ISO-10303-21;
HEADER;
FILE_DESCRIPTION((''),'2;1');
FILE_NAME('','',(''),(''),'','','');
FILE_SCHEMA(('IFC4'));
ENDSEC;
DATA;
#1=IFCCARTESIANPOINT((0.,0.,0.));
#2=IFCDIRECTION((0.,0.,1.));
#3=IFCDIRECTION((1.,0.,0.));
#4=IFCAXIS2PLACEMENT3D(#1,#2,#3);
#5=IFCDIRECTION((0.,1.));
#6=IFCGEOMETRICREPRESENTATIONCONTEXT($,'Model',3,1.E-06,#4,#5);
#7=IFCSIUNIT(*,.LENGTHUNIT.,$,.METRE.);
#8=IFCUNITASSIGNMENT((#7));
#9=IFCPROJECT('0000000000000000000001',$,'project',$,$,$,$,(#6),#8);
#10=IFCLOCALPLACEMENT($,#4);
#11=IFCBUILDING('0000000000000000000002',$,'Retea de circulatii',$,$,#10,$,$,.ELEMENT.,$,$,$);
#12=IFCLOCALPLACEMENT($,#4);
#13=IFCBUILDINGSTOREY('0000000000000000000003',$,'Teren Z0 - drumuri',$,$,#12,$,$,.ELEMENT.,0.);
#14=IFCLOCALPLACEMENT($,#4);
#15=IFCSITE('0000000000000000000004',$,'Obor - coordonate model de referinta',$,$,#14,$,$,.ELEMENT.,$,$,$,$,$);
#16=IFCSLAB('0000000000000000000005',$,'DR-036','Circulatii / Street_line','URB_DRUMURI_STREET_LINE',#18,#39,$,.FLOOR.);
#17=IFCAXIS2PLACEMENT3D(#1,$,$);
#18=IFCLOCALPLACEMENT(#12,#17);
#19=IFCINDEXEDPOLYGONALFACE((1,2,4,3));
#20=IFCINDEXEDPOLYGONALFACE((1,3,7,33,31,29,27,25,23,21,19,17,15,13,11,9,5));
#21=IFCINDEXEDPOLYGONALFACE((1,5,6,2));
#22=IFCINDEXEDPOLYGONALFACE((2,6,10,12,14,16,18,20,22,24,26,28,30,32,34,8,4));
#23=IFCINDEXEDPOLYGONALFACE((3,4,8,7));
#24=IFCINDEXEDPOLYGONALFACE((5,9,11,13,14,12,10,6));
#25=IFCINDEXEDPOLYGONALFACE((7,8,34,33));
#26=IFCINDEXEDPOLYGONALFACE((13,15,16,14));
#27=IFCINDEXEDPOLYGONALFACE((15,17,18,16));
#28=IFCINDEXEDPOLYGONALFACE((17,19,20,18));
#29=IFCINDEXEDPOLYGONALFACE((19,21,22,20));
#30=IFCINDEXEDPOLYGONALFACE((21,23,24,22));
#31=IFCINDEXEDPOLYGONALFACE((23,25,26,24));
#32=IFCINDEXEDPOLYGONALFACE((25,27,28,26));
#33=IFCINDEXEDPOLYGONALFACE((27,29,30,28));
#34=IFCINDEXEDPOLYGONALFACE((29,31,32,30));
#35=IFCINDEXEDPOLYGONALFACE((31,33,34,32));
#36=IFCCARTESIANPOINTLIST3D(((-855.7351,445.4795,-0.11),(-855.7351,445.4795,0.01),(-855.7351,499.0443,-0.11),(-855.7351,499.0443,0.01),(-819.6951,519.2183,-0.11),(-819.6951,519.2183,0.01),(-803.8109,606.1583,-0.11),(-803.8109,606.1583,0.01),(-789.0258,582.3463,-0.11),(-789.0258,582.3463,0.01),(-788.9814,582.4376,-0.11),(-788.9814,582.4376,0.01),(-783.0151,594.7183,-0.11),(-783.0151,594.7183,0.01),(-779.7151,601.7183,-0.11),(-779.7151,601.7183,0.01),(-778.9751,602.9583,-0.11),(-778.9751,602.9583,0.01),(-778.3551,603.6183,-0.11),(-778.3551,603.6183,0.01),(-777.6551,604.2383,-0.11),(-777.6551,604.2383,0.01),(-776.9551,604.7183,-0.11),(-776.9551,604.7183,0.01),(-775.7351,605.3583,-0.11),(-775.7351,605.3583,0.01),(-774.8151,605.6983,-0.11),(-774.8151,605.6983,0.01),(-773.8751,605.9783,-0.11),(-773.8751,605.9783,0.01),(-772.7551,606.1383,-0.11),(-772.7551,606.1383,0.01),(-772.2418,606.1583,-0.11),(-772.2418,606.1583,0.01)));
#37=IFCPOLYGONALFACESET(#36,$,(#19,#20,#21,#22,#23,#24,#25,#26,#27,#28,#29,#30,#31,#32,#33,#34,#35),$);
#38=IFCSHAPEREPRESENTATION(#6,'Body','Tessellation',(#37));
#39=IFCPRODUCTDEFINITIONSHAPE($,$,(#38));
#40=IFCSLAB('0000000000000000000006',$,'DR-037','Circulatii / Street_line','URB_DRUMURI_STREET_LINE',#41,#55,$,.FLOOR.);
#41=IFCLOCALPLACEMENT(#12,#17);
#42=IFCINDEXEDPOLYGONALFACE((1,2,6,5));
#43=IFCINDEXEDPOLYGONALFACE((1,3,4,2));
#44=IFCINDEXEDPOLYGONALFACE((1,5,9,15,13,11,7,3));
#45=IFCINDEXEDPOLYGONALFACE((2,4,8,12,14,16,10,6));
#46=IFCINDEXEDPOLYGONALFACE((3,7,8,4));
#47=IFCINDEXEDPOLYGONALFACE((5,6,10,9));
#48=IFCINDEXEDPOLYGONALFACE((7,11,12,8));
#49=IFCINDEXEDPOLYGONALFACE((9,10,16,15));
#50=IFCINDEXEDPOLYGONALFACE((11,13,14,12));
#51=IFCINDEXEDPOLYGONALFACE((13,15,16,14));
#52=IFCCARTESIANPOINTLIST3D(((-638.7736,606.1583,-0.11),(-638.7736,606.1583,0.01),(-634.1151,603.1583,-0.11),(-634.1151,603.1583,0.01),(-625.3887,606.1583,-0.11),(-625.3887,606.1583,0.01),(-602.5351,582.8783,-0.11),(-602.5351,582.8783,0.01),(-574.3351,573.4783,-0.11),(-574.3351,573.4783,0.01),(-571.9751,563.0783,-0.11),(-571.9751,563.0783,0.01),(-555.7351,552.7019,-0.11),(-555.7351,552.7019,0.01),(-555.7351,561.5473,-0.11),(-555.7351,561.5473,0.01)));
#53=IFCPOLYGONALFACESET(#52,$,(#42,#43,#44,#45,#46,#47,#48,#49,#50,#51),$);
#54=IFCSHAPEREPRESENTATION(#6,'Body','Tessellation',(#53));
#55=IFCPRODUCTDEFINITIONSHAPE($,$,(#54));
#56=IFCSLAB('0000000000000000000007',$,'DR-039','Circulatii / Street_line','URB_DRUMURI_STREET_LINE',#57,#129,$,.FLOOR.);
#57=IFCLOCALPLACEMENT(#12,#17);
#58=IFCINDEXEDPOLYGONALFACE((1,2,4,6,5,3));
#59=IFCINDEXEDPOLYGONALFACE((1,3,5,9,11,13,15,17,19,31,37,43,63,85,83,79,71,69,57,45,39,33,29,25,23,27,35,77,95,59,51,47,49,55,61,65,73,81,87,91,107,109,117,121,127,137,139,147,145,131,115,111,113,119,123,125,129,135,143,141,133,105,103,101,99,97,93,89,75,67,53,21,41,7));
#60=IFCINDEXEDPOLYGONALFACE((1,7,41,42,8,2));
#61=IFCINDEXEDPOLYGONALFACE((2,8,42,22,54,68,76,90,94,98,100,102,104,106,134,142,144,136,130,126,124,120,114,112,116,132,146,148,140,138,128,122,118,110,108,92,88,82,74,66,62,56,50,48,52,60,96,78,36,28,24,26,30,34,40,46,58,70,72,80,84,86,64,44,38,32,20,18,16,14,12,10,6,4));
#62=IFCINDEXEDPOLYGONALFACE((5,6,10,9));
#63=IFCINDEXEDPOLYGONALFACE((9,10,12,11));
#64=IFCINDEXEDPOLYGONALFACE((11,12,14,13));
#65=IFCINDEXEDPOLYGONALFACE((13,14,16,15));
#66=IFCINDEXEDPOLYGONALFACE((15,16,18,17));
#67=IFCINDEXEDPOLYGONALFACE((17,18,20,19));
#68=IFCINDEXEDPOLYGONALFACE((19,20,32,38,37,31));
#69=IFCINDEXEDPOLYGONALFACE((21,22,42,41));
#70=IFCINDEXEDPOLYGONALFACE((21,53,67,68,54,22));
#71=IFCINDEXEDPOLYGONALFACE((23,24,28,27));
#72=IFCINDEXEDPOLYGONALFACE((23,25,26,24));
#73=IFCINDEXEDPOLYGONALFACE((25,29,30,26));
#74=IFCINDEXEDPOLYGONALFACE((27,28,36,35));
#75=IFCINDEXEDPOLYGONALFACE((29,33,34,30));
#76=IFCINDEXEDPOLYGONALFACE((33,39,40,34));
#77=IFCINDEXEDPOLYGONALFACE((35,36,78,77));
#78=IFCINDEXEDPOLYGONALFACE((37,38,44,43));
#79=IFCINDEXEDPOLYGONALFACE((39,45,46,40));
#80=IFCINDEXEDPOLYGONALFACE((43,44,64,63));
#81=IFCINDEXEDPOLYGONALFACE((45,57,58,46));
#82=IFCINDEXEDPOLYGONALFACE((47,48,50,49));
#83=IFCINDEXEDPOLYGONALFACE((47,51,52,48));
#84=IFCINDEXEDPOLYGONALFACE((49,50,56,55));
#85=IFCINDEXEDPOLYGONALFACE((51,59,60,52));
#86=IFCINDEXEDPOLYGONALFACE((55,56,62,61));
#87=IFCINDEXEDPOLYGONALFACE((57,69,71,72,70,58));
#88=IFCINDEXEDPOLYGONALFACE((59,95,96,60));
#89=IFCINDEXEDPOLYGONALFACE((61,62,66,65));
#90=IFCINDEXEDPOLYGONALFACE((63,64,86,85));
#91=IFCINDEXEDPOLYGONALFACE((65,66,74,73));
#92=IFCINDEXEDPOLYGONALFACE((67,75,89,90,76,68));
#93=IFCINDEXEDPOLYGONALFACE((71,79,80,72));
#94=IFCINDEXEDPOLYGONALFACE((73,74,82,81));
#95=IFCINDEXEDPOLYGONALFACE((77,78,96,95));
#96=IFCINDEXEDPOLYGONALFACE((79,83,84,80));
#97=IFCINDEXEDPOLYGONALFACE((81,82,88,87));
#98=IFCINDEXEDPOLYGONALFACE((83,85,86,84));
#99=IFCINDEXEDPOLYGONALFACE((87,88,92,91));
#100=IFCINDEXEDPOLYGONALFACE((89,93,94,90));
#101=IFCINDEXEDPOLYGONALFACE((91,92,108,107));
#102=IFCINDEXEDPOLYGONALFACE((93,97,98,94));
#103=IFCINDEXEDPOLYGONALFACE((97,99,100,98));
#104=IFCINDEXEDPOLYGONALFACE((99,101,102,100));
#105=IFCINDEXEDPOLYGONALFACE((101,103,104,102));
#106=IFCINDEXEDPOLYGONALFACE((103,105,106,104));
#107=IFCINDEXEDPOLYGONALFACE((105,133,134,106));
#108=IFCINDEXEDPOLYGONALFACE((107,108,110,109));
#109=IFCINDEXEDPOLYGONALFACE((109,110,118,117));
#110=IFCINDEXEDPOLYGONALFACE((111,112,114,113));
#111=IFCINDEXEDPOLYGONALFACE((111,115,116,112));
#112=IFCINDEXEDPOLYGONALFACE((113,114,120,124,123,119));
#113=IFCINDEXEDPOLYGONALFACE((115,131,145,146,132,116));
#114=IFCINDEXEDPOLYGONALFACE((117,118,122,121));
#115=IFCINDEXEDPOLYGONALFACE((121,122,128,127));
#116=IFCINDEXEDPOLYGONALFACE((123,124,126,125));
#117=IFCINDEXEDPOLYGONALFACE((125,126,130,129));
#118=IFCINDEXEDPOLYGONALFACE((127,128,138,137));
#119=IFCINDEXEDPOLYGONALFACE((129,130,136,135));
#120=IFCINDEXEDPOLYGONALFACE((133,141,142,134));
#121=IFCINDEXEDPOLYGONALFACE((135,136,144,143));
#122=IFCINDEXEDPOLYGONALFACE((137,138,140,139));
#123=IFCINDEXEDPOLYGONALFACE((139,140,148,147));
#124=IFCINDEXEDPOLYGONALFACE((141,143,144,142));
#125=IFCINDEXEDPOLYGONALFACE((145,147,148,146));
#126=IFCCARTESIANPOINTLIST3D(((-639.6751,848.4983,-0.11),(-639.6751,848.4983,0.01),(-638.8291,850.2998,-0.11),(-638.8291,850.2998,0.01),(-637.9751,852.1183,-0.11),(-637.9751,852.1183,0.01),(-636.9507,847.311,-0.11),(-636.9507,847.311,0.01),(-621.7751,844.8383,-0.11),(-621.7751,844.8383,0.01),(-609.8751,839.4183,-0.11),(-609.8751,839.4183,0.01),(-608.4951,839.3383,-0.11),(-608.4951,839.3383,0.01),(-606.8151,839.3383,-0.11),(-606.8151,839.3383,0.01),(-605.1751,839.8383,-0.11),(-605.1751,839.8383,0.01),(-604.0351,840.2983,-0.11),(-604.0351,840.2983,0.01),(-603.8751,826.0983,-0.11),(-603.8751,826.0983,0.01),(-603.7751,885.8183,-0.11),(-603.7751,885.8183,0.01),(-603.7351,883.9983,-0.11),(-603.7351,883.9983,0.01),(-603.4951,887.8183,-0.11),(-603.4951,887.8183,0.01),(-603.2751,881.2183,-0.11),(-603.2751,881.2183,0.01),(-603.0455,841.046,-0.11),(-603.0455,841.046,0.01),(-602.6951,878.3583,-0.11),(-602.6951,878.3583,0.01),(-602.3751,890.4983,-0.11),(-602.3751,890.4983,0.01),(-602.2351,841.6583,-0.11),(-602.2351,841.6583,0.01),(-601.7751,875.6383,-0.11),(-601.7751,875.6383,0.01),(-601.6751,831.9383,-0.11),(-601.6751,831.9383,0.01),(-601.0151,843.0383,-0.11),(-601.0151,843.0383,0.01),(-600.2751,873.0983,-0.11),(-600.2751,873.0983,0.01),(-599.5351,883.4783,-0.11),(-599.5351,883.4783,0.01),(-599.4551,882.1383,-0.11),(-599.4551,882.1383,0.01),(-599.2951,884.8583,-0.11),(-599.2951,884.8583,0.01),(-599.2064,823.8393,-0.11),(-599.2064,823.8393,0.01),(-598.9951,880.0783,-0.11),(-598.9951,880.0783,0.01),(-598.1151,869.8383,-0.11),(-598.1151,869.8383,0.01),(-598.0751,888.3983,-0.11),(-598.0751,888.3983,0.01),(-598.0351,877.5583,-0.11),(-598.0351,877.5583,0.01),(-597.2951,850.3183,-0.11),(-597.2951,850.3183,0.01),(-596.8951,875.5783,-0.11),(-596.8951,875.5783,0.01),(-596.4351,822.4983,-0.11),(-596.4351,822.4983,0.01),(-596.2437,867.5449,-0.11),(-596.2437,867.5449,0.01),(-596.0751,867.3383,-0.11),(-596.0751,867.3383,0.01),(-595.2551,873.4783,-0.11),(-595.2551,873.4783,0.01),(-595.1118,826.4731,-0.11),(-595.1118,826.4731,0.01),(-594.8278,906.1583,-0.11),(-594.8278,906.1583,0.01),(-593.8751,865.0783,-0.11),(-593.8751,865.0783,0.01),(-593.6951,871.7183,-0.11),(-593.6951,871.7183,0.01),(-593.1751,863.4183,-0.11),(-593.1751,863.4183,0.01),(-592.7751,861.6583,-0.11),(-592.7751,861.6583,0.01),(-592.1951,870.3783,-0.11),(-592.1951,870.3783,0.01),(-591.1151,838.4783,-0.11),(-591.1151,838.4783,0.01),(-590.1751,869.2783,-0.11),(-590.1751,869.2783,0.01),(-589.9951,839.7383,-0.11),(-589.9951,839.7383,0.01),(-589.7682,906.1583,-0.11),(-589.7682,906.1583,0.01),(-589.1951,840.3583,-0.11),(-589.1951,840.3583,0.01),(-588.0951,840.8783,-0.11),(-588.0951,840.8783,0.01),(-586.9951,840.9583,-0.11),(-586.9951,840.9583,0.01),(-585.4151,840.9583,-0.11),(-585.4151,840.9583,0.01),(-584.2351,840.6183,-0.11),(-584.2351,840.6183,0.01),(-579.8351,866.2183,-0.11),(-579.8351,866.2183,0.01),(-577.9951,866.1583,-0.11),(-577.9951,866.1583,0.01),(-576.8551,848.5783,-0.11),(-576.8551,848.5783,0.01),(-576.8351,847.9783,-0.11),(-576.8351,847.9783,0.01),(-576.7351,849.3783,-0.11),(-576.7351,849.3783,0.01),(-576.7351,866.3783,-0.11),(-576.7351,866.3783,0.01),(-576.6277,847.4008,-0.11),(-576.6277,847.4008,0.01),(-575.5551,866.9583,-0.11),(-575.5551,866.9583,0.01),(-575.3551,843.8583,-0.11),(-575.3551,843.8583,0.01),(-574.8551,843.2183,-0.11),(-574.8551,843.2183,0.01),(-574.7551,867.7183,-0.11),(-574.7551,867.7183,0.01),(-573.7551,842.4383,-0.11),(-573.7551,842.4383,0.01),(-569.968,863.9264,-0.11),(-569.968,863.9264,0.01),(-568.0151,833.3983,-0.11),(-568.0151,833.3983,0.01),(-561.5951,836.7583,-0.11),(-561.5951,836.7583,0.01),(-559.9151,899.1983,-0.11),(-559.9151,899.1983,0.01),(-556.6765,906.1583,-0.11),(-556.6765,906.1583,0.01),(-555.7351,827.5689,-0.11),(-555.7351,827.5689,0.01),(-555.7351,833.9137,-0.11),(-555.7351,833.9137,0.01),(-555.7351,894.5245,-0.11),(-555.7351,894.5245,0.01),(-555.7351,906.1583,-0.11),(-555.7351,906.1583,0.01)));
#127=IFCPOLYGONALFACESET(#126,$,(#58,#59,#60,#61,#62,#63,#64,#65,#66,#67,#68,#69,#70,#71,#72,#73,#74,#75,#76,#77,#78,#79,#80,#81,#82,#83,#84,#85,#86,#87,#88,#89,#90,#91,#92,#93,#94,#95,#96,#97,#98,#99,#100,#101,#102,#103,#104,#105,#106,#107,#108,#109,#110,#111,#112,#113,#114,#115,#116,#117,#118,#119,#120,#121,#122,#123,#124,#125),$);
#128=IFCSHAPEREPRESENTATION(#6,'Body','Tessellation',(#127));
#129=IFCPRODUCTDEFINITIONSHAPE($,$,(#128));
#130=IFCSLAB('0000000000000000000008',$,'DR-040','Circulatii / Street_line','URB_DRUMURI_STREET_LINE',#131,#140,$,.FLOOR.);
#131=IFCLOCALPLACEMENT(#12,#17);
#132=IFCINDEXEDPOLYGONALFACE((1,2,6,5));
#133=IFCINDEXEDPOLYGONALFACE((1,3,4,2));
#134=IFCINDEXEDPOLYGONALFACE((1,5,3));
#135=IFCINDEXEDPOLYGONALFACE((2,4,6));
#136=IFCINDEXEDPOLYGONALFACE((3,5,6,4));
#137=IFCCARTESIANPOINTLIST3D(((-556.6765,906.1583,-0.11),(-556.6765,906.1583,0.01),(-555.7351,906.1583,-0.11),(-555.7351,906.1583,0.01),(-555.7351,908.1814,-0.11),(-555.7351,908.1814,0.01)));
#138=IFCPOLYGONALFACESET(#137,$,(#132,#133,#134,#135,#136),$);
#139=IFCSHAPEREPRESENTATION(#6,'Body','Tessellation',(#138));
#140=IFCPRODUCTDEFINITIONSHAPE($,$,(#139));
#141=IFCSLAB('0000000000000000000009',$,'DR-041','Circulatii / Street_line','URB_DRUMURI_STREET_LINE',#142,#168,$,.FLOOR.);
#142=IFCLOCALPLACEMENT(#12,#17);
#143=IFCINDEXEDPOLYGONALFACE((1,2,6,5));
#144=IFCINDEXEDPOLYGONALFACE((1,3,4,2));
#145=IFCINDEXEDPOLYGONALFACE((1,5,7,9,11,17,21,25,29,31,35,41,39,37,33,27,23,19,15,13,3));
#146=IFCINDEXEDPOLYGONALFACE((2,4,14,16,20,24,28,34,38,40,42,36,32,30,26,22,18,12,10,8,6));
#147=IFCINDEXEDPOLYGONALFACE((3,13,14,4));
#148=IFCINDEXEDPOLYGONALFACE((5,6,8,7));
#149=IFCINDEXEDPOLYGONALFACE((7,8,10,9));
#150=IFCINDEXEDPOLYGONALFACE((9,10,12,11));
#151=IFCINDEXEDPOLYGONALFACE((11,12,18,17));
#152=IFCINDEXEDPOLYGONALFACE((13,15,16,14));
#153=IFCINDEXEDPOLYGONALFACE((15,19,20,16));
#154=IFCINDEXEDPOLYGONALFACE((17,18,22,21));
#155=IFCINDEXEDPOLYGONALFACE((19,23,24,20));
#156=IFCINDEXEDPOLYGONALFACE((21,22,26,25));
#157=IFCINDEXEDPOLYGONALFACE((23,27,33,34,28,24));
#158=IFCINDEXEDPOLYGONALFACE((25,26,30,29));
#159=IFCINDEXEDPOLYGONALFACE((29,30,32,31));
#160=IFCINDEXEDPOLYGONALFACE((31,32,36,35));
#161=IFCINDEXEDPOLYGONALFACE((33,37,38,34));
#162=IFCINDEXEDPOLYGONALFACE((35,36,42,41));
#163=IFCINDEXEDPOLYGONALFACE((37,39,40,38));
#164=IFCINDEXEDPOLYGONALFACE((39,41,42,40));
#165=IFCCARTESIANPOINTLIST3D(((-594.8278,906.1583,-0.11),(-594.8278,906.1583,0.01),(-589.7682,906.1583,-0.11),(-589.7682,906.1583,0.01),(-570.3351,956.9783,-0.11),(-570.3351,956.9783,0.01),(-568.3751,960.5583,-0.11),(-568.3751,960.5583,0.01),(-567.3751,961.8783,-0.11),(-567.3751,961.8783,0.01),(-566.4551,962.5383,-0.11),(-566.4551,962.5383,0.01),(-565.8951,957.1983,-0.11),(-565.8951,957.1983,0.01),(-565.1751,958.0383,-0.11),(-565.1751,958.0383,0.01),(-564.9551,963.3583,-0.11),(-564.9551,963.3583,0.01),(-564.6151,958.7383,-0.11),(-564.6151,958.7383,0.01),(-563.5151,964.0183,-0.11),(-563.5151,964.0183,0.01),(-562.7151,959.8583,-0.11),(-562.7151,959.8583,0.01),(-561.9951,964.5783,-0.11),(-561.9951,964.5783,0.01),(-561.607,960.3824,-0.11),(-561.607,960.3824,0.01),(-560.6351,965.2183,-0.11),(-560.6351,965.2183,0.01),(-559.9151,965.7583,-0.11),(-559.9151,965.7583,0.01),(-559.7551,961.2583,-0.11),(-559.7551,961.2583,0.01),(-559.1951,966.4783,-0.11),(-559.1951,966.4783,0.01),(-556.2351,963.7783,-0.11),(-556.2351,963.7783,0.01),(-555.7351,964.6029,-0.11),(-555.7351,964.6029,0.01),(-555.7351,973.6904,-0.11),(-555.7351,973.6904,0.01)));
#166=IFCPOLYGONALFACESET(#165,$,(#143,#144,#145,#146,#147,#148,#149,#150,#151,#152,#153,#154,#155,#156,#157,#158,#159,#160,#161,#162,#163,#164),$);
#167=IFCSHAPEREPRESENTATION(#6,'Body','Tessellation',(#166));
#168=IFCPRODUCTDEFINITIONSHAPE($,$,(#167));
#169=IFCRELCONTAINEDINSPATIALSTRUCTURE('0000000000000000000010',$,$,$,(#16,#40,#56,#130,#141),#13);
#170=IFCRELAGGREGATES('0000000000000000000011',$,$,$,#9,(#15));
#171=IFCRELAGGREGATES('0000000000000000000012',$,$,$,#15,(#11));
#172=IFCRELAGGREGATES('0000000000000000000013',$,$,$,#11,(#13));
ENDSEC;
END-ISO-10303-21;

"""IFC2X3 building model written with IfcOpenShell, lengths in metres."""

from ifc_helpers import new_model, si_unit, direction, frame, origin_with_axes, place, context, project, spatial, polyline, outline, extrude, element, save


model = new_model("IFC2X3")

# Units and contexts
model_context = context("Model", 3, precision=1e-06, world=origin_with_axes(), true_north=direction((0.0, 1.0)))
ifc_project = project(units=[si_unit("LENGTHUNIT", "METRE")], contexts=[model_context])

# Site, building, storey
site_placement = place(None, origin_with_axes())
site = spatial("IfcSite", under=ifc_project, at=site_placement, Name="Obor - coordonate model de referinta", CompositionType="ELEMENT")
building_placement = place(None, origin_with_axes())
building = spatial("IfcBuilding", under=site, at=building_placement, Name="Retea de circulatii", CompositionType="ELEMENT")
storey_placement = place(None, origin_with_axes())
storey = spatial("IfcBuildingStorey", under=building, at=storey_placement, Name="Teren Z0 - drumuri", CompositionType="ELEMENT", Elevation=0.0)

# Slabs
slab_1_placement = place(None, origin_with_axes())
element("IfcSlab", 1, at=slab_1_placement, inside=storey, Name="DR-036", Description="Circulatii / Street_line", ObjectType="URB_DRUMURI_STREET_LINE", PredefinedType="FLOOR", context=model_context, shape_type="SweptSolid", body=[
    extrude(outline(polyline([(-772.7551, 606.1383), (-772.2418, 606.1583), (-803.8109, 606.1583), (-855.7351, 499.0443), (-855.7351, 445.4795), (-819.6951, 519.2183), (-789.0258, 582.3463), (-788.9814, 582.4376), (-783.0151, 594.7183), (-779.7151, 601.7183), (-778.9751, 602.9583), (-778.3551, 603.6183), (-777.6551, 604.2383), (-776.9551, 604.7183), (-775.7351, 605.3583), (-774.8151, 605.6983), (-773.8751, 605.9783), (-772.7551, 606.1383)])), frame((0.0, 0.0, -0.11), z_axis=(0.0, 0.0, 1.0), x_axis=(1.0, 0.0, 0.0)), (0.0, 0.0, 1.0), 0.12),
])
slab_2_placement = place(None, origin_with_axes())
element("IfcSlab", 2, at=slab_2_placement, inside=storey, Name="DR-037", Description="Circulatii / Street_line", ObjectType="URB_DRUMURI_STREET_LINE", PredefinedType="FLOOR", context=model_context, shape_type="SweptSolid", body=[
    extrude(outline(polyline([(-634.1151, 603.1583), (-602.5351, 582.8783), (-571.9751, 563.0783), (-555.7351, 552.7019), (-555.7351, 561.5473), (-574.3351, 573.4783), (-625.3887, 606.1583), (-638.7736, 606.1583), (-634.1151, 603.1583)])), frame((0.0, 0.0, -0.11), z_axis=(0.0, 0.0, 1.0), x_axis=(1.0, 0.0, 0.0)), (0.0, 0.0, 1.0), 0.12),
])
slab_3_placement = place(None, origin_with_axes())
element("IfcSlab", 3, at=slab_3_placement, inside=storey, Name="DR-039", Description="Circulatii / Street_line", ObjectType="URB_DRUMURI_STREET_LINE", PredefinedType="FLOOR", context=model_context, shape_type="SweptSolid", body=[
    extrude(outline(polyline([(-584.2351, 840.6183), (-568.0151, 833.3983), (-555.7351, 827.5689), (-555.7351, 833.9137), (-561.5951, 836.7583), (-573.7551, 842.4383), (-574.8551, 843.2183), (-575.3551, 843.8583), (-576.6277, 847.4008), (-576.8351, 847.9783), (-576.8551, 848.5783), (-576.7351, 849.3783), (-569.968, 863.9264), (-555.7351, 894.5245), (-555.7351, 906.1583), (-556.6765, 906.1583), (-559.9151, 899.1983), (-574.7551, 867.7183), (-575.5551, 866.9583), (-576.7351, 866.3783), (-577.9951, 866.1583), (-579.8351, 866.2183), (-590.1751, 869.2783), (-592.1951, 870.3783), (-593.6951, 871.7183), (-595.2551, 873.4783), (-596.8951, 875.5783), (-598.0351, 877.5583), (-598.9951, 880.0783), (-599.4551, 882.1383), (-599.5351, 883.4783), (-599.2951, 884.8583), (-598.0751, 888.3983), (-589.7682, 906.1583), (-594.8278, 906.1583), (-602.3751, 890.4983), (-603.4951, 887.8183), (-603.7751, 885.8183), (-603.7351, 883.9983), (-603.2751, 881.2183), (-602.6951, 878.3583), (-601.7751, 875.6383), (-600.2751, 873.0983), (-598.1151, 869.8383), (-596.2437, 867.5449), (-596.0751, 867.3383), (-593.8751, 865.0783), (-593.1751, 863.4183), (-592.7751, 861.6583), (-597.2951, 850.3183), (-601.0151, 843.0383), (-602.2351, 841.6583), (-603.0455, 841.046), (-604.0351, 840.2983), (-605.1751, 839.8383), (-606.8151, 839.3383), (-608.4951, 839.3383), (-609.8751, 839.4183), (-621.7751, 844.8383), (-637.9751, 852.1183), (-638.8291, 850.2998), (-639.6751, 848.4983), (-636.9507, 847.311), (-601.6751, 831.9383), (-603.8751, 826.0983), (-599.2064, 823.8393), (-596.4351, 822.4983), (-595.1118, 826.4731), (-591.1151, 838.4783), (-589.9951, 839.7383), (-589.1951, 840.3583), (-588.0951, 840.8783), (-586.9951, 840.9583), (-585.4151, 840.9583), (-584.2351, 840.6183)])), frame((0.0, 0.0, -0.11), z_axis=(0.0, 0.0, 1.0), x_axis=(1.0, 0.0, 0.0)), (0.0, 0.0, 1.0), 0.12),
])
slab_4_placement = place(None, origin_with_axes())
element("IfcSlab", 4, at=slab_4_placement, inside=storey, Name="DR-040", Description="Circulatii / Street_line", ObjectType="URB_DRUMURI_STREET_LINE", PredefinedType="FLOOR", context=model_context, shape_type="SweptSolid", body=[
    extrude(outline(polyline([(-555.7351, 906.1583), (-555.7351, 908.1814), (-556.6765, 906.1583), (-555.7351, 906.1583)])), frame((0.0, 0.0, -0.11), z_axis=(0.0, 0.0, 1.0), x_axis=(1.0, 0.0, 0.0)), (0.0, 0.0, 1.0), 0.12),
])
slab_5_placement = place(None, origin_with_axes())
element("IfcSlab", 5, at=slab_5_placement, inside=storey, Name="DR-041", Description="Circulatii / Street_line", ObjectType="URB_DRUMURI_STREET_LINE", PredefinedType="FLOOR", context=model_context, shape_type="SweptSolid", body=[
    extrude(outline(polyline([(-567.3751, 961.8783), (-568.3751, 960.5583), (-570.3351, 956.9783), (-594.8278, 906.1583), (-589.7682, 906.1583), (-565.8951, 957.1983), (-565.1751, 958.0383), (-564.6151, 958.7383), (-562.7151, 959.8583), (-561.607, 960.3824), (-559.7551, 961.2583), (-556.2351, 963.7783), (-555.7351, 964.6029), (-555.7351, 973.6904), (-559.1951, 966.4783), (-559.9151, 965.7583), (-560.6351, 965.2183), (-561.9951, 964.5783), (-563.5151, 964.0183), (-564.9551, 963.3583), (-566.4551, 962.5383), (-567.3751, 961.8783)])), frame((0.0, 0.0, -0.11), z_axis=(0.0, 0.0, 1.0), x_axis=(1.0, 0.0, 0.0)), (0.0, 0.0, 1.0), 0.12),
])

save(model, "model.ifc")
